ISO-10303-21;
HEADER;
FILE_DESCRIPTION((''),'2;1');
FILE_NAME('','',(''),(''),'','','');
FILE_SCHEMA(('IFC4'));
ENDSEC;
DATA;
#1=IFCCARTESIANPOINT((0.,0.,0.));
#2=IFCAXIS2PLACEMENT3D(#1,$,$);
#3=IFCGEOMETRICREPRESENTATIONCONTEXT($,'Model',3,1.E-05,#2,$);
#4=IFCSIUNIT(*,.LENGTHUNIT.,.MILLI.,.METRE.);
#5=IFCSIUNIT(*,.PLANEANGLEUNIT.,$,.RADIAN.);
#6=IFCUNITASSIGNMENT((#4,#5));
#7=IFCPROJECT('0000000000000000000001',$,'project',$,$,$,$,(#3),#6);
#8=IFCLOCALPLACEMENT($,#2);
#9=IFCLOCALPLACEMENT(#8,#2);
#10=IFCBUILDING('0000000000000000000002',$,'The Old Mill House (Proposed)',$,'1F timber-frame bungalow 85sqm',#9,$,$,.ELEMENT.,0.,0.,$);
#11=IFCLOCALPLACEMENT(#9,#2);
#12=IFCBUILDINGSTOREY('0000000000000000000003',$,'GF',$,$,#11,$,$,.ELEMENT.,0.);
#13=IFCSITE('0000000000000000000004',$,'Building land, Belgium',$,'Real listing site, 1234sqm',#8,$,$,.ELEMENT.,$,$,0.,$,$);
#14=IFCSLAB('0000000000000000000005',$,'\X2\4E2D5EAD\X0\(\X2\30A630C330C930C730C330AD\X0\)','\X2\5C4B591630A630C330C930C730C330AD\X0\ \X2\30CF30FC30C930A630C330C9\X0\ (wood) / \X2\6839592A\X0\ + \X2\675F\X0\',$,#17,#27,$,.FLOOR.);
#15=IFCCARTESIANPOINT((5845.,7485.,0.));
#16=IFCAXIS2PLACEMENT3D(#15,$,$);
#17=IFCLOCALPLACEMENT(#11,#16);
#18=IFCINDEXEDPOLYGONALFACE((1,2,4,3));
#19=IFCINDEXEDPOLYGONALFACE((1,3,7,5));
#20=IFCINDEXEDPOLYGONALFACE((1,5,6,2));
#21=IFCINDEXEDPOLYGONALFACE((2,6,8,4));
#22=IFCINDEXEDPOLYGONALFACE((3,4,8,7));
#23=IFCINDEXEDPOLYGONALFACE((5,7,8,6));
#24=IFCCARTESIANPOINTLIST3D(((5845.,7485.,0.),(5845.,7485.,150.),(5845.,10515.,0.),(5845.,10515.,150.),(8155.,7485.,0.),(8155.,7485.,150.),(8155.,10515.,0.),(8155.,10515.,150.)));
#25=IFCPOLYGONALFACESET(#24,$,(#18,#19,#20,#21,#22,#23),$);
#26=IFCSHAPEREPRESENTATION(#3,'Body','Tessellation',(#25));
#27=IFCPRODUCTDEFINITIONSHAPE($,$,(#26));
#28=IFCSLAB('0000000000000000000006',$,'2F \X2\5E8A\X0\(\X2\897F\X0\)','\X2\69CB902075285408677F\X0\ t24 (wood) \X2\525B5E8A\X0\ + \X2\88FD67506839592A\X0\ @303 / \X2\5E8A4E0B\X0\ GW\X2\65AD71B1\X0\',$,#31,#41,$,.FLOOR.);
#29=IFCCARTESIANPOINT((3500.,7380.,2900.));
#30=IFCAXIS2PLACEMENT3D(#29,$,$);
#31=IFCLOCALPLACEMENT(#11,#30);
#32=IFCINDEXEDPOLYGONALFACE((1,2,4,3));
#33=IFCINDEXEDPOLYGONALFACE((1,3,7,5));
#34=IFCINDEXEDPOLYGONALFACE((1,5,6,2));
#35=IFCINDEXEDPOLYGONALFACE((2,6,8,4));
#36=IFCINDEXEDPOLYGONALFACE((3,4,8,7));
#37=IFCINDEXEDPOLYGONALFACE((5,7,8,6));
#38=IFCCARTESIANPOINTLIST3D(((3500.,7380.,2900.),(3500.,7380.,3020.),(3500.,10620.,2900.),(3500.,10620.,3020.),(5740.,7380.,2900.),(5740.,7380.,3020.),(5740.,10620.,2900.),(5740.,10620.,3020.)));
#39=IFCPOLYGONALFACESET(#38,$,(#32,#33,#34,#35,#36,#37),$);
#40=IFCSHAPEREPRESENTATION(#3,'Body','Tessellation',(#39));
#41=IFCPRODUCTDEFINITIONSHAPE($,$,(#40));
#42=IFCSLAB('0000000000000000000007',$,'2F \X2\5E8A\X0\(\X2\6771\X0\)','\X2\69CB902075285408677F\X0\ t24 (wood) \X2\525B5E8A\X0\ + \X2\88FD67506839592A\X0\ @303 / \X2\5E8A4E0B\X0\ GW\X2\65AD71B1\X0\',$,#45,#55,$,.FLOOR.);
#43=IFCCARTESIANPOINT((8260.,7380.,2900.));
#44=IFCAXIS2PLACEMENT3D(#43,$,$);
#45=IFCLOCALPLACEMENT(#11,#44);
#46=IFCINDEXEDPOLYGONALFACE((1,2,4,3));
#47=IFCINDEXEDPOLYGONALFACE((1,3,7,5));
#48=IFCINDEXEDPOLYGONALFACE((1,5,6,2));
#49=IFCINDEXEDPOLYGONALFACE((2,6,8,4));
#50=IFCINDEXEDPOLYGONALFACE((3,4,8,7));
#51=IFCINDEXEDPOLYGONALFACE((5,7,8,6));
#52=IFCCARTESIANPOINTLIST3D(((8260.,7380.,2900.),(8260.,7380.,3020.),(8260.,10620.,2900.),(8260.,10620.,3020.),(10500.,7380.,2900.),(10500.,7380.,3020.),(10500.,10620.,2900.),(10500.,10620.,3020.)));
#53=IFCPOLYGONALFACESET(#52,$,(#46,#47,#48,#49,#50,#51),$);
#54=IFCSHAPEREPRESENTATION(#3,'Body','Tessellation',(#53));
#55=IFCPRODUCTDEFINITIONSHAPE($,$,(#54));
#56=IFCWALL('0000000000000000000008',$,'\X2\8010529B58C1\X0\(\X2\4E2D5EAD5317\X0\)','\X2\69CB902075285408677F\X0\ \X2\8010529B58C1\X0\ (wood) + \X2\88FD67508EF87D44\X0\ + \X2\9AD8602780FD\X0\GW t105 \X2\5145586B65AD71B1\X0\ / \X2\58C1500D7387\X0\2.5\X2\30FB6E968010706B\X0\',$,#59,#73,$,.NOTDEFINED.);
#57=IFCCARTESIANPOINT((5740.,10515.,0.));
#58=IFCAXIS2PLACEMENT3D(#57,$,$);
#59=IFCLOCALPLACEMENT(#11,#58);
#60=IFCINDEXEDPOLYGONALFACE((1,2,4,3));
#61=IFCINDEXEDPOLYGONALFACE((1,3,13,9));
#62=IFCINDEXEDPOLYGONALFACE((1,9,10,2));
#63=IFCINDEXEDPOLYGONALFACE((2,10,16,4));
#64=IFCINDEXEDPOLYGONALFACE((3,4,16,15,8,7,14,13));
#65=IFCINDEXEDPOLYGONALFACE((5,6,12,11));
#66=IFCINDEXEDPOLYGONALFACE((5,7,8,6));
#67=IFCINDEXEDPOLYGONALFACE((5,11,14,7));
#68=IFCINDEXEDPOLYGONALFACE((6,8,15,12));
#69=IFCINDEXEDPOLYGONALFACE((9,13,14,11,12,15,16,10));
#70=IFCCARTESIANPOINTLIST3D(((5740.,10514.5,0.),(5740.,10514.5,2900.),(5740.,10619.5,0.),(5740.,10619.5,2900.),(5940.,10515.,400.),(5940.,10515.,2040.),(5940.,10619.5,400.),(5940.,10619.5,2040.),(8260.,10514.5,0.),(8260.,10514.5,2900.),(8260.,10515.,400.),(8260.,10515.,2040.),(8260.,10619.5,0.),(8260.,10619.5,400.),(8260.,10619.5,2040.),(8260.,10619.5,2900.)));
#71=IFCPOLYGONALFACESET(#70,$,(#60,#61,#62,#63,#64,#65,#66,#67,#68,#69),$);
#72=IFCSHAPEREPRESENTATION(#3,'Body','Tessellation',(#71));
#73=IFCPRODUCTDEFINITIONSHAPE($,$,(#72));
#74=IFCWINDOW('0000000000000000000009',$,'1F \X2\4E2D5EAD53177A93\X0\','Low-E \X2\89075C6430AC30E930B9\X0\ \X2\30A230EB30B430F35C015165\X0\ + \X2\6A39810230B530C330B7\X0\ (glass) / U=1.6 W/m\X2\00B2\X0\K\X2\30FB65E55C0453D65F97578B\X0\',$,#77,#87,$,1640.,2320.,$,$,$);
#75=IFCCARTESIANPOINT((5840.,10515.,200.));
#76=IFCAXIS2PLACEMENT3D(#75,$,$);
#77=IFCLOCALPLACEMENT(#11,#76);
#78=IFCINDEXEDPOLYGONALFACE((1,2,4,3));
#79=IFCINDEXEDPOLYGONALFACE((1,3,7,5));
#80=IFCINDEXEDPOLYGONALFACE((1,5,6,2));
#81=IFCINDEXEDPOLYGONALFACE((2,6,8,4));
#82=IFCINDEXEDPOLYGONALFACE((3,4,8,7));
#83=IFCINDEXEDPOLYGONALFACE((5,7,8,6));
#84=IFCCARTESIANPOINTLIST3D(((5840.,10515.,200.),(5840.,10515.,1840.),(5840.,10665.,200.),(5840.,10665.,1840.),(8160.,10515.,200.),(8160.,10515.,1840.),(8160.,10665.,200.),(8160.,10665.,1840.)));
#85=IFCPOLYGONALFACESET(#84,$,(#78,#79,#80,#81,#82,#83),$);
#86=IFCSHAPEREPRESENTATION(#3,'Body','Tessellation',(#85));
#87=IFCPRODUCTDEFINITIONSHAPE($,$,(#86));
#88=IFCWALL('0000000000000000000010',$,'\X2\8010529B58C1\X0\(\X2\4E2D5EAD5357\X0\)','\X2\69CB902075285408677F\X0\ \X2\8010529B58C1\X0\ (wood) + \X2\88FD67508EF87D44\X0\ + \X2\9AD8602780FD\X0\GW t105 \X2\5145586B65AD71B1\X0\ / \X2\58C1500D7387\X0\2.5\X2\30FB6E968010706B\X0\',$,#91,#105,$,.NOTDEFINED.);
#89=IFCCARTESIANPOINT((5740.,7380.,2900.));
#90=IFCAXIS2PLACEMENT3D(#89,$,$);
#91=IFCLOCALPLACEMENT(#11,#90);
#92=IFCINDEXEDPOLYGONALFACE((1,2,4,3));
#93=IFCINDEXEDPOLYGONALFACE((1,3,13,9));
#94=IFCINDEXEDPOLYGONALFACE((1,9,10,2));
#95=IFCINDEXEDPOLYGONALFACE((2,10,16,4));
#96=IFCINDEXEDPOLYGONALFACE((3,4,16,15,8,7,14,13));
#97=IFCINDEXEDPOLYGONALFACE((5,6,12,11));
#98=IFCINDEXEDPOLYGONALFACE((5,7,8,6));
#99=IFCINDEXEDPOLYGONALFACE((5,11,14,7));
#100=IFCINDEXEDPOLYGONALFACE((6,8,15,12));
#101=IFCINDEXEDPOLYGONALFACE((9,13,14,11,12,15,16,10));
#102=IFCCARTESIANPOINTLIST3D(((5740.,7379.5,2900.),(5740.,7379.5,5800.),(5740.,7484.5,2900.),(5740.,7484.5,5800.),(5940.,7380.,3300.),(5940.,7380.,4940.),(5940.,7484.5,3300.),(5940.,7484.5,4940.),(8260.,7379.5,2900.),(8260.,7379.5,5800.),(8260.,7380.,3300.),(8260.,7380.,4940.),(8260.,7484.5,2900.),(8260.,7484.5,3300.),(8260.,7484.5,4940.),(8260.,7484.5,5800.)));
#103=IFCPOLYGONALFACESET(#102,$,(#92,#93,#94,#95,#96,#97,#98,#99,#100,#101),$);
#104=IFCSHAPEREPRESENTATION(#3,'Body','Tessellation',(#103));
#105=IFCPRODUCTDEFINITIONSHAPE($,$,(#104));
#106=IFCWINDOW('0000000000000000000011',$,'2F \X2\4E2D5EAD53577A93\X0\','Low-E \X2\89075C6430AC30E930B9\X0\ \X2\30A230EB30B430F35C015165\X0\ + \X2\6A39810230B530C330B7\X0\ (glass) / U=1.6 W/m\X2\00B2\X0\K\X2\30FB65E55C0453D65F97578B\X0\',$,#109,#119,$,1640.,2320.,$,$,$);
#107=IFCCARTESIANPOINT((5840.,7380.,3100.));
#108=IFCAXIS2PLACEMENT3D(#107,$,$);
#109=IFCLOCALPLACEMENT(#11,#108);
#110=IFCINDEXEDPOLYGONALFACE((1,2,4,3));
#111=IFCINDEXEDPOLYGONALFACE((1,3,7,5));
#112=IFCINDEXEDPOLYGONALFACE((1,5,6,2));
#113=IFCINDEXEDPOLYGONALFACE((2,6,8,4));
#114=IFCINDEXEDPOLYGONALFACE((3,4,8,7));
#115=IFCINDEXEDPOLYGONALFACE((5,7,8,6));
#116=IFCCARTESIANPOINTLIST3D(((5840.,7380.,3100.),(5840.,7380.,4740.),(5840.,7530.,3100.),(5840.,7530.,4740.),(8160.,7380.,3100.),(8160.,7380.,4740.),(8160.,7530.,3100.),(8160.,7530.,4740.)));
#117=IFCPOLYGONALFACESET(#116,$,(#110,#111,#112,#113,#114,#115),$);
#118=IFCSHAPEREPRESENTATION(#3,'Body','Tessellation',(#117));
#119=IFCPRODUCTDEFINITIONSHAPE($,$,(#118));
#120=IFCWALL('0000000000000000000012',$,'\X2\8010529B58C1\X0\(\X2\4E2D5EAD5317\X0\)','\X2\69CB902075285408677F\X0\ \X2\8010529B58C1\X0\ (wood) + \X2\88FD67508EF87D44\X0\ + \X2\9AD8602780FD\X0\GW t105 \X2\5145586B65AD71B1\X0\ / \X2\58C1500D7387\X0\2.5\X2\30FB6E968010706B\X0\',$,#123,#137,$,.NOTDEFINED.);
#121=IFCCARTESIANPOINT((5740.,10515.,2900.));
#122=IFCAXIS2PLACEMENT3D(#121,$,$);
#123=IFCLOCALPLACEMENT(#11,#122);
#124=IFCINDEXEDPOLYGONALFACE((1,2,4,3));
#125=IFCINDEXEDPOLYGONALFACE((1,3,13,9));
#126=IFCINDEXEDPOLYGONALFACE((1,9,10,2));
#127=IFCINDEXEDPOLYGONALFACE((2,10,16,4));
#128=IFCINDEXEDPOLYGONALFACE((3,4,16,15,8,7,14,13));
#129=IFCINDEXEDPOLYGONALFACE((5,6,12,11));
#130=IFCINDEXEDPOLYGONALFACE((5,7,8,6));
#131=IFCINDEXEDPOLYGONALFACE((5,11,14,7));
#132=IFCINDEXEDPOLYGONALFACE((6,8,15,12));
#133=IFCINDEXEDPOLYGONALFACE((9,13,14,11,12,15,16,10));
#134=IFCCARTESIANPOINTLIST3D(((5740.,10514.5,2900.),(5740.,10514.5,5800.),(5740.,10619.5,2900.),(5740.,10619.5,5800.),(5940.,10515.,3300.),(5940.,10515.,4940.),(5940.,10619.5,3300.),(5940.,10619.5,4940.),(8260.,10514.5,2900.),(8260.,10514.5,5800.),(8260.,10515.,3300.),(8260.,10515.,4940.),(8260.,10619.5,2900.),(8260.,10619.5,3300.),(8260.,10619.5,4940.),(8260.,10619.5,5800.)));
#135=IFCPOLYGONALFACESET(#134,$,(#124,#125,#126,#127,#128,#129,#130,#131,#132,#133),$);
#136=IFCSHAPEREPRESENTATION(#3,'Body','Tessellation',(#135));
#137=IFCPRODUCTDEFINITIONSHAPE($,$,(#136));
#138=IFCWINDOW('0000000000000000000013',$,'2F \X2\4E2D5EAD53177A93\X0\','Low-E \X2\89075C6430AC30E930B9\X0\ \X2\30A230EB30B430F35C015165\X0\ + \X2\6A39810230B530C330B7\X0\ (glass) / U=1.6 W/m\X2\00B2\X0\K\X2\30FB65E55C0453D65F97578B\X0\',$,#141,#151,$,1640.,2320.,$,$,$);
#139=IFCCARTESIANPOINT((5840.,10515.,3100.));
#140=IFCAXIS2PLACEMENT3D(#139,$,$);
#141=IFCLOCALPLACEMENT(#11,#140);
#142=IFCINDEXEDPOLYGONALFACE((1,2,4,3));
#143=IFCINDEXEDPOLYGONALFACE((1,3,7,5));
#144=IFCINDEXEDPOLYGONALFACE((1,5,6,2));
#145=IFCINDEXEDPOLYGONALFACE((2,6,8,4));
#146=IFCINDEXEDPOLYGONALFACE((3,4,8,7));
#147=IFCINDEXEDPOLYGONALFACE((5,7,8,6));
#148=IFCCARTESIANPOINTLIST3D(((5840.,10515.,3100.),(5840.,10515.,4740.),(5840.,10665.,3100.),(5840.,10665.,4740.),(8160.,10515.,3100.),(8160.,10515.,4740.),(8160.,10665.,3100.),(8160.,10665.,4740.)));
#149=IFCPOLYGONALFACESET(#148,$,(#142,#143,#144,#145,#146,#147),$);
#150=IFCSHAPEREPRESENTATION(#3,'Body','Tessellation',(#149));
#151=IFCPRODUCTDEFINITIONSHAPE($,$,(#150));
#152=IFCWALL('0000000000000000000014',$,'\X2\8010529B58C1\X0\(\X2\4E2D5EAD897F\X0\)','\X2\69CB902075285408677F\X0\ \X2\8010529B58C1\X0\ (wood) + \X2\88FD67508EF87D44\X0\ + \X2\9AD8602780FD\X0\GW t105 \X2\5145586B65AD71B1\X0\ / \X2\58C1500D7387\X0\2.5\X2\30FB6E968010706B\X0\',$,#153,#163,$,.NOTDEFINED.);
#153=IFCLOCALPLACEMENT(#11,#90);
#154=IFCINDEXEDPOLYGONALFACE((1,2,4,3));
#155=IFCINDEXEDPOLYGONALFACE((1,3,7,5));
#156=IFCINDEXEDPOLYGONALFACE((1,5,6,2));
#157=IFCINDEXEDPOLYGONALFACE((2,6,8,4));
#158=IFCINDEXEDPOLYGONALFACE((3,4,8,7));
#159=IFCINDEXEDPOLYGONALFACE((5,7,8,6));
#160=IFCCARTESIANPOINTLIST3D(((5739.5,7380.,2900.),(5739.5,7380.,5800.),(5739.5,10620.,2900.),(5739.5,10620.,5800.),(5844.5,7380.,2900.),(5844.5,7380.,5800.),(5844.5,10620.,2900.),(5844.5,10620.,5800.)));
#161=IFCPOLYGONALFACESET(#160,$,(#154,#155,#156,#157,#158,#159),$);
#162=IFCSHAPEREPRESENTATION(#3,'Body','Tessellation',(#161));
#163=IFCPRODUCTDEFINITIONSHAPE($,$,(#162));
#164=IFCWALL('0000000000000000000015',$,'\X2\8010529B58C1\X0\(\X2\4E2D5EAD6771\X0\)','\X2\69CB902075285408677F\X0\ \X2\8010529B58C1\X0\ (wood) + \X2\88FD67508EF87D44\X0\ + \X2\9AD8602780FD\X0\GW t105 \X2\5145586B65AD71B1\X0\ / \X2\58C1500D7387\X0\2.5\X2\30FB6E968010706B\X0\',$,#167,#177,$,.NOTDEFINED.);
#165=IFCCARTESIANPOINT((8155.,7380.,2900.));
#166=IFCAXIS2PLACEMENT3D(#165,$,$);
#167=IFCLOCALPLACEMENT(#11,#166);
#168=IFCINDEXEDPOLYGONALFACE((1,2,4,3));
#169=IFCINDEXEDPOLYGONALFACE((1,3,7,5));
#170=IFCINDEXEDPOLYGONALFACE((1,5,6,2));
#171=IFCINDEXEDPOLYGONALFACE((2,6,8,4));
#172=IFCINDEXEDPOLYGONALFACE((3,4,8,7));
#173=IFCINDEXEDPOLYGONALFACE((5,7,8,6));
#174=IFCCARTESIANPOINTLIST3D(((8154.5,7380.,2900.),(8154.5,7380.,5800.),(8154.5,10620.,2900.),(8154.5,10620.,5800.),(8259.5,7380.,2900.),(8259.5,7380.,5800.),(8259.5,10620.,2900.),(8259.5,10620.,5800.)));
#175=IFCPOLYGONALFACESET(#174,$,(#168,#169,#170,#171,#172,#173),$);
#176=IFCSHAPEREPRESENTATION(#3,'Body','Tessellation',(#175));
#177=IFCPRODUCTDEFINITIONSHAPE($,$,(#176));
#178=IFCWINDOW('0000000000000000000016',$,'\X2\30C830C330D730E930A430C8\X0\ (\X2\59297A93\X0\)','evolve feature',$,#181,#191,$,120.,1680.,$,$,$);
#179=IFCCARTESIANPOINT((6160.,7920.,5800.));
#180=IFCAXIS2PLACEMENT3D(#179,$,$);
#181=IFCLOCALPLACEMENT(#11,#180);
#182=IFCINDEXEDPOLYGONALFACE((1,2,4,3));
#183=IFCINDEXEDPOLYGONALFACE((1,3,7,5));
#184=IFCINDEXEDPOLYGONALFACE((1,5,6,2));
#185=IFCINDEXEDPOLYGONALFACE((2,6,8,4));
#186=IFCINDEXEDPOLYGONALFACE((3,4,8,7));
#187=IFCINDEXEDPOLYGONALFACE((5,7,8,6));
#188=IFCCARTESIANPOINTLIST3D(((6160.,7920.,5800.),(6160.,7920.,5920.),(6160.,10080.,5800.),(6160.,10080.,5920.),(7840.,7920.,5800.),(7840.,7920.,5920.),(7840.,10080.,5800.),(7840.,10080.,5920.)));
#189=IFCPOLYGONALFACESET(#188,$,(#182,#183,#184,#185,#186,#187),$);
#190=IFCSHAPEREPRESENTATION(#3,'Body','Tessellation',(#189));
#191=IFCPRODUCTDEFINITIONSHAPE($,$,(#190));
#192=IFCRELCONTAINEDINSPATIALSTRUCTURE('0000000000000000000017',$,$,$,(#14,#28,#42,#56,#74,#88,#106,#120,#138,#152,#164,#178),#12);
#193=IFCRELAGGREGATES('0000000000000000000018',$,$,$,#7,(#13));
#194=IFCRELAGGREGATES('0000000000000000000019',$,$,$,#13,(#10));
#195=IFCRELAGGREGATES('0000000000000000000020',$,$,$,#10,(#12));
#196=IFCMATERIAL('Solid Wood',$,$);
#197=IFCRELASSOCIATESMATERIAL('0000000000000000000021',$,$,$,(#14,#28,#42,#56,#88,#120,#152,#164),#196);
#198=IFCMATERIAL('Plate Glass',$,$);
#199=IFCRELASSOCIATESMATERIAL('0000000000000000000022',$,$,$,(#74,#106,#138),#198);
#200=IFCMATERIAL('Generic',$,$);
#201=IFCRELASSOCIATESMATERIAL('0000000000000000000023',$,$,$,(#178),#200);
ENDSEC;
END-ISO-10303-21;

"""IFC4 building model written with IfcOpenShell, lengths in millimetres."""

from ifc_helpers import new_model, si_unit, frame, frame_2d, origin, place, context, project, spatial, rectangle, extrude, material, element, fill, save


model = new_model("IFC4")

# Units and contexts
model_context = context("Model", 3, precision=1e-05, world=origin())
ifc_project = project(units=[si_unit("LENGTHUNIT", "METRE", prefix="MILLI"), si_unit("PLANEANGLEUNIT", "RADIAN")], contexts=[model_context])

# Site, building, storey
site_placement = place(None, origin())
site = spatial("IfcSite", under=ifc_project, at=site_placement, Name="Building land, Belgium", ObjectType="Real listing site, 1234sqm", CompositionType="ELEMENT", RefElevation=0.0)
building_placement = place(site_placement, origin())
building = spatial("IfcBuilding", under=site, at=building_placement, Name="The Old Mill House (Proposed)", ObjectType="1F timber-frame bungalow 85sqm", CompositionType="ELEMENT", ElevationOfRefHeight=0.0, ElevationOfTerrain=0.0)
storey_placement = place(building_placement, origin())
storey = spatial("IfcBuildingStorey", under=building, at=storey_placement, Name="GF", CompositionType="ELEMENT", Elevation=0.0)

# Slabs
ifc_material_1 = material(Name="Solid Wood")
slab_1_placement = place(storey_placement, frame((5845.0, 7485.0, 0.0)))
element("IfcSlab", 1, at=slab_1_placement, inside=storey, material=ifc_material_1, Name="中庭(ウッドデッキ)", Description="屋外ウッドデッキ ハードウッド (wood) / 根太 + 束", PredefinedType="FLOOR", context=model_context, shape_type="SweptSolid", body=[
    extrude(rectangle(XDim=2310.0, YDim=3030.0, at=frame_2d((1155.0, 1515.0))), frame((5845.0, 7485.0, 0.0)), (0.0, 0.0, 1.0), 150.0),
])
slab_2_placement = place(storey_placement, frame((3500.0, 7380.0, 2900.0)))
element("IfcSlab", 2, at=slab_2_placement, inside=storey, material=ifc_material_1, Name="2F 床(西)", Description="構造用合板 t24 (wood) 剛床 + 製材根太 @303 / 床下 GW断熱", PredefinedType="FLOOR", context=model_context, shape_type="SweptSolid", body=[
    extrude(rectangle(XDim=2240.0, YDim=3240.0, at=frame_2d((1120.0, 1620.0))), frame((3500.0, 7380.0, 2900.0)), (0.0, 0.0, 1.0), 120.0),
])
slab_3_placement = place(storey_placement, frame((8260.0, 7380.0, 2900.0)))
element("IfcSlab", 3, at=slab_3_placement, inside=storey, material=ifc_material_1, Name="2F 床(東)", Description="構造用合板 t24 (wood) 剛床 + 製材根太 @303 / 床下 GW断熱", PredefinedType="FLOOR", context=model_context, shape_type="SweptSolid", body=[
    extrude(rectangle(XDim=2240.0, YDim=3240.0, at=frame_2d((1120.0, 1620.0))), frame((8260.0, 7380.0, 2900.0)), (0.0, 0.0, 1.0), 120.0),
])

# Walls, openings, windows
wall_1_placement = place(storey_placement, frame((5740.0, 10515.0, 0.0)))
wall_1 = element("IfcWall", 4, at=wall_1_placement, inside=storey, material=ifc_material_1, Name="耐力壁(中庭北)", Description="構造用合板 耐力壁 (wood) + 製材軸組 + 高性能GW t105 充填断熱 / 壁倍率2.5・準耐火", PredefinedType="NOTDEFINED", context=model_context, shape_type="SweptSolid", body=[
    extrude(rectangle(XDim=2520.0, YDim=105.0, at=frame_2d((1260.0, 52.0))), frame((5740.0, 10515.0, 0.0)), (0.0, 0.0, 1.0), 2900.0),
])
opening_1_placement = place(storey_placement, frame((5840.0, 10515.0, 200.0)))
opening_1 = element("IfcOpeningElement", 5, at=opening_1_placement, cuts=wall_1, PredefinedType="NOTDEFINED", context=model_context, shape_type="SweptSolid", body=[
    extrude(rectangle(XDim=2320.0, YDim=150.0, at=frame_2d((1160.0, 75.0))), frame((5840.0, 10515.0, 200.0)), (0.0, 0.0, 1.0), 1640.0),
])
ifc_material_2 = material(Name="Plate Glass")
window_1_placement = place(storey_placement, frame((5840.0, 10515.0, 200.0)))
window_1 = element("IfcWindow", 6, at=window_1_placement, inside=storey, material=ifc_material_2, Name="1F 中庭北窓", Description="Low-E 複層ガラス アルゴン封入 + 樹脂サッシ (glass) / U=1.6 W/m²K・日射取得型", OverallHeight=1640.0, OverallWidth=2320.0, context=model_context, shape_type="SweptSolid", body=[
    extrude(rectangle(XDim=2320.0, YDim=150.0, at=frame_2d((1160.0, 75.0))), frame((5840.0, 10515.0, 200.0)), (0.0, 0.0, 1.0), 1640.0),
])
fill(opening_1, window_1)
wall_2_placement = place(storey_placement, frame((5740.0, 7380.0, 2900.0)))
wall_2 = element("IfcWall", 7, at=wall_2_placement, inside=storey, material=ifc_material_1, Name="耐力壁(中庭南)", Description="構造用合板 耐力壁 (wood) + 製材軸組 + 高性能GW t105 充填断熱 / 壁倍率2.5・準耐火", PredefinedType="NOTDEFINED", context=model_context, shape_type="SweptSolid", body=[
    extrude(rectangle(XDim=2520.0, YDim=105.0, at=frame_2d((1260.0, 52.0))), frame((5740.0, 7380.0, 2900.0)), (0.0, 0.0, 1.0), 2900.0),
])
opening_2_placement = place(storey_placement, frame((5840.0, 7380.0, 3100.0)))
opening_2 = element("IfcOpeningElement", 8, at=opening_2_placement, cuts=wall_2, PredefinedType="NOTDEFINED", context=model_context, shape_type="SweptSolid", body=[
    extrude(rectangle(XDim=2320.0, YDim=150.0, at=frame_2d((1160.0, 75.0))), frame((5840.0, 7380.0, 3100.0)), (0.0, 0.0, 1.0), 1640.0),
])
window_2_placement = place(storey_placement, frame((5840.0, 7380.0, 3100.0)))
window_2 = element("IfcWindow", 9, at=window_2_placement, inside=storey, material=ifc_material_2, Name="2F 中庭南窓", Description="Low-E 複層ガラス アルゴン封入 + 樹脂サッシ (glass) / U=1.6 W/m²K・日射取得型", OverallHeight=1640.0, OverallWidth=2320.0, context=model_context, shape_type="SweptSolid", body=[
    extrude(rectangle(XDim=2320.0, YDim=150.0, at=frame_2d((1160.0, 75.0))), frame((5840.0, 7380.0, 3100.0)), (0.0, 0.0, 1.0), 1640.0),
])
fill(opening_2, window_2)
wall_3_placement = place(storey_placement, frame((5740.0, 10515.0, 2900.0)))
wall_3 = element("IfcWall", 10, at=wall_3_placement, inside=storey, material=ifc_material_1, Name="耐力壁(中庭北)", Description="構造用合板 耐力壁 (wood) + 製材軸組 + 高性能GW t105 充填断熱 / 壁倍率2.5・準耐火", PredefinedType="NOTDEFINED", context=model_context, shape_type="SweptSolid", body=[
    extrude(rectangle(XDim=2520.0, YDim=105.0, at=frame_2d((1260.0, 52.0))), frame((5740.0, 10515.0, 2900.0)), (0.0, 0.0, 1.0), 2900.0),
])
opening_3_placement = place(storey_placement, frame((5840.0, 10515.0, 3100.0)))
opening_3 = element("IfcOpeningElement", 11, at=opening_3_placement, cuts=wall_3, PredefinedType="NOTDEFINED", context=model_context, shape_type="SweptSolid", body=[
    extrude(rectangle(XDim=2320.0, YDim=150.0, at=frame_2d((1160.0, 75.0))), frame((5840.0, 10515.0, 3100.0)), (0.0, 0.0, 1.0), 1640.0),
])
window_3_placement = place(storey_placement, frame((5840.0, 10515.0, 3100.0)))
window_3 = element("IfcWindow", 12, at=window_3_placement, inside=storey, material=ifc_material_2, Name="2F 中庭北窓", Description="Low-E 複層ガラス アルゴン封入 + 樹脂サッシ (glass) / U=1.6 W/m²K・日射取得型", OverallHeight=1640.0, OverallWidth=2320.0, context=model_context, shape_type="SweptSolid", body=[
    extrude(rectangle(XDim=2320.0, YDim=150.0, at=frame_2d((1160.0, 75.0))), frame((5840.0, 10515.0, 3100.0)), (0.0, 0.0, 1.0), 1640.0),
])
fill(opening_3, window_3)

# Walls
wall_4_placement = place(storey_placement, frame((5740.0, 7380.0, 2900.0)))
element("IfcWall", 13, at=wall_4_placement, inside=storey, material=ifc_material_1, Name="耐力壁(中庭西)", Description="構造用合板 耐力壁 (wood) + 製材軸組 + 高性能GW t105 充填断熱 / 壁倍率2.5・準耐火", PredefinedType="NOTDEFINED", context=model_context, shape_type="SweptSolid", body=[
    extrude(rectangle(XDim=105.0, YDim=3240.0, at=frame_2d((52.0, 1620.0))), frame((5740.0, 7380.0, 2900.0)), (0.0, 0.0, 1.0), 2900.0),
])
wall_5_placement = place(storey_placement, frame((8155.0, 7380.0, 2900.0)))
element("IfcWall", 14, at=wall_5_placement, inside=storey, material=ifc_material_1, Name="耐力壁(中庭東)", Description="構造用合板 耐力壁 (wood) + 製材軸組 + 高性能GW t105 充填断熱 / 壁倍率2.5・準耐火", PredefinedType="NOTDEFINED", context=model_context, shape_type="SweptSolid", body=[
    extrude(rectangle(XDim=105.0, YDim=3240.0, at=frame_2d((52.0, 1620.0))), frame((8155.0, 7380.0, 2900.0)), (0.0, 0.0, 1.0), 2900.0),
])

# Window
ifc_material_3 = material(Name="Generic")
window_4_placement = place(storey_placement, frame((6160.0, 7920.0, 5800.0)))
element("IfcWindow", 15, at=window_4_placement, inside=storey, material=ifc_material_3, Name="トップライト (天窓)", Description="evolve feature", OverallHeight=120.0, OverallWidth=1680.0, context=model_context, shape_type="SweptSolid", body=[
    extrude(rectangle(XDim=1680.0, YDim=2160.0, at=frame_2d((840.0, 1080.0))), frame((6160.0, 7920.0, 5800.0)), (0.0, 0.0, 1.0), 120.0),
])

save(model, "model.ifc")
